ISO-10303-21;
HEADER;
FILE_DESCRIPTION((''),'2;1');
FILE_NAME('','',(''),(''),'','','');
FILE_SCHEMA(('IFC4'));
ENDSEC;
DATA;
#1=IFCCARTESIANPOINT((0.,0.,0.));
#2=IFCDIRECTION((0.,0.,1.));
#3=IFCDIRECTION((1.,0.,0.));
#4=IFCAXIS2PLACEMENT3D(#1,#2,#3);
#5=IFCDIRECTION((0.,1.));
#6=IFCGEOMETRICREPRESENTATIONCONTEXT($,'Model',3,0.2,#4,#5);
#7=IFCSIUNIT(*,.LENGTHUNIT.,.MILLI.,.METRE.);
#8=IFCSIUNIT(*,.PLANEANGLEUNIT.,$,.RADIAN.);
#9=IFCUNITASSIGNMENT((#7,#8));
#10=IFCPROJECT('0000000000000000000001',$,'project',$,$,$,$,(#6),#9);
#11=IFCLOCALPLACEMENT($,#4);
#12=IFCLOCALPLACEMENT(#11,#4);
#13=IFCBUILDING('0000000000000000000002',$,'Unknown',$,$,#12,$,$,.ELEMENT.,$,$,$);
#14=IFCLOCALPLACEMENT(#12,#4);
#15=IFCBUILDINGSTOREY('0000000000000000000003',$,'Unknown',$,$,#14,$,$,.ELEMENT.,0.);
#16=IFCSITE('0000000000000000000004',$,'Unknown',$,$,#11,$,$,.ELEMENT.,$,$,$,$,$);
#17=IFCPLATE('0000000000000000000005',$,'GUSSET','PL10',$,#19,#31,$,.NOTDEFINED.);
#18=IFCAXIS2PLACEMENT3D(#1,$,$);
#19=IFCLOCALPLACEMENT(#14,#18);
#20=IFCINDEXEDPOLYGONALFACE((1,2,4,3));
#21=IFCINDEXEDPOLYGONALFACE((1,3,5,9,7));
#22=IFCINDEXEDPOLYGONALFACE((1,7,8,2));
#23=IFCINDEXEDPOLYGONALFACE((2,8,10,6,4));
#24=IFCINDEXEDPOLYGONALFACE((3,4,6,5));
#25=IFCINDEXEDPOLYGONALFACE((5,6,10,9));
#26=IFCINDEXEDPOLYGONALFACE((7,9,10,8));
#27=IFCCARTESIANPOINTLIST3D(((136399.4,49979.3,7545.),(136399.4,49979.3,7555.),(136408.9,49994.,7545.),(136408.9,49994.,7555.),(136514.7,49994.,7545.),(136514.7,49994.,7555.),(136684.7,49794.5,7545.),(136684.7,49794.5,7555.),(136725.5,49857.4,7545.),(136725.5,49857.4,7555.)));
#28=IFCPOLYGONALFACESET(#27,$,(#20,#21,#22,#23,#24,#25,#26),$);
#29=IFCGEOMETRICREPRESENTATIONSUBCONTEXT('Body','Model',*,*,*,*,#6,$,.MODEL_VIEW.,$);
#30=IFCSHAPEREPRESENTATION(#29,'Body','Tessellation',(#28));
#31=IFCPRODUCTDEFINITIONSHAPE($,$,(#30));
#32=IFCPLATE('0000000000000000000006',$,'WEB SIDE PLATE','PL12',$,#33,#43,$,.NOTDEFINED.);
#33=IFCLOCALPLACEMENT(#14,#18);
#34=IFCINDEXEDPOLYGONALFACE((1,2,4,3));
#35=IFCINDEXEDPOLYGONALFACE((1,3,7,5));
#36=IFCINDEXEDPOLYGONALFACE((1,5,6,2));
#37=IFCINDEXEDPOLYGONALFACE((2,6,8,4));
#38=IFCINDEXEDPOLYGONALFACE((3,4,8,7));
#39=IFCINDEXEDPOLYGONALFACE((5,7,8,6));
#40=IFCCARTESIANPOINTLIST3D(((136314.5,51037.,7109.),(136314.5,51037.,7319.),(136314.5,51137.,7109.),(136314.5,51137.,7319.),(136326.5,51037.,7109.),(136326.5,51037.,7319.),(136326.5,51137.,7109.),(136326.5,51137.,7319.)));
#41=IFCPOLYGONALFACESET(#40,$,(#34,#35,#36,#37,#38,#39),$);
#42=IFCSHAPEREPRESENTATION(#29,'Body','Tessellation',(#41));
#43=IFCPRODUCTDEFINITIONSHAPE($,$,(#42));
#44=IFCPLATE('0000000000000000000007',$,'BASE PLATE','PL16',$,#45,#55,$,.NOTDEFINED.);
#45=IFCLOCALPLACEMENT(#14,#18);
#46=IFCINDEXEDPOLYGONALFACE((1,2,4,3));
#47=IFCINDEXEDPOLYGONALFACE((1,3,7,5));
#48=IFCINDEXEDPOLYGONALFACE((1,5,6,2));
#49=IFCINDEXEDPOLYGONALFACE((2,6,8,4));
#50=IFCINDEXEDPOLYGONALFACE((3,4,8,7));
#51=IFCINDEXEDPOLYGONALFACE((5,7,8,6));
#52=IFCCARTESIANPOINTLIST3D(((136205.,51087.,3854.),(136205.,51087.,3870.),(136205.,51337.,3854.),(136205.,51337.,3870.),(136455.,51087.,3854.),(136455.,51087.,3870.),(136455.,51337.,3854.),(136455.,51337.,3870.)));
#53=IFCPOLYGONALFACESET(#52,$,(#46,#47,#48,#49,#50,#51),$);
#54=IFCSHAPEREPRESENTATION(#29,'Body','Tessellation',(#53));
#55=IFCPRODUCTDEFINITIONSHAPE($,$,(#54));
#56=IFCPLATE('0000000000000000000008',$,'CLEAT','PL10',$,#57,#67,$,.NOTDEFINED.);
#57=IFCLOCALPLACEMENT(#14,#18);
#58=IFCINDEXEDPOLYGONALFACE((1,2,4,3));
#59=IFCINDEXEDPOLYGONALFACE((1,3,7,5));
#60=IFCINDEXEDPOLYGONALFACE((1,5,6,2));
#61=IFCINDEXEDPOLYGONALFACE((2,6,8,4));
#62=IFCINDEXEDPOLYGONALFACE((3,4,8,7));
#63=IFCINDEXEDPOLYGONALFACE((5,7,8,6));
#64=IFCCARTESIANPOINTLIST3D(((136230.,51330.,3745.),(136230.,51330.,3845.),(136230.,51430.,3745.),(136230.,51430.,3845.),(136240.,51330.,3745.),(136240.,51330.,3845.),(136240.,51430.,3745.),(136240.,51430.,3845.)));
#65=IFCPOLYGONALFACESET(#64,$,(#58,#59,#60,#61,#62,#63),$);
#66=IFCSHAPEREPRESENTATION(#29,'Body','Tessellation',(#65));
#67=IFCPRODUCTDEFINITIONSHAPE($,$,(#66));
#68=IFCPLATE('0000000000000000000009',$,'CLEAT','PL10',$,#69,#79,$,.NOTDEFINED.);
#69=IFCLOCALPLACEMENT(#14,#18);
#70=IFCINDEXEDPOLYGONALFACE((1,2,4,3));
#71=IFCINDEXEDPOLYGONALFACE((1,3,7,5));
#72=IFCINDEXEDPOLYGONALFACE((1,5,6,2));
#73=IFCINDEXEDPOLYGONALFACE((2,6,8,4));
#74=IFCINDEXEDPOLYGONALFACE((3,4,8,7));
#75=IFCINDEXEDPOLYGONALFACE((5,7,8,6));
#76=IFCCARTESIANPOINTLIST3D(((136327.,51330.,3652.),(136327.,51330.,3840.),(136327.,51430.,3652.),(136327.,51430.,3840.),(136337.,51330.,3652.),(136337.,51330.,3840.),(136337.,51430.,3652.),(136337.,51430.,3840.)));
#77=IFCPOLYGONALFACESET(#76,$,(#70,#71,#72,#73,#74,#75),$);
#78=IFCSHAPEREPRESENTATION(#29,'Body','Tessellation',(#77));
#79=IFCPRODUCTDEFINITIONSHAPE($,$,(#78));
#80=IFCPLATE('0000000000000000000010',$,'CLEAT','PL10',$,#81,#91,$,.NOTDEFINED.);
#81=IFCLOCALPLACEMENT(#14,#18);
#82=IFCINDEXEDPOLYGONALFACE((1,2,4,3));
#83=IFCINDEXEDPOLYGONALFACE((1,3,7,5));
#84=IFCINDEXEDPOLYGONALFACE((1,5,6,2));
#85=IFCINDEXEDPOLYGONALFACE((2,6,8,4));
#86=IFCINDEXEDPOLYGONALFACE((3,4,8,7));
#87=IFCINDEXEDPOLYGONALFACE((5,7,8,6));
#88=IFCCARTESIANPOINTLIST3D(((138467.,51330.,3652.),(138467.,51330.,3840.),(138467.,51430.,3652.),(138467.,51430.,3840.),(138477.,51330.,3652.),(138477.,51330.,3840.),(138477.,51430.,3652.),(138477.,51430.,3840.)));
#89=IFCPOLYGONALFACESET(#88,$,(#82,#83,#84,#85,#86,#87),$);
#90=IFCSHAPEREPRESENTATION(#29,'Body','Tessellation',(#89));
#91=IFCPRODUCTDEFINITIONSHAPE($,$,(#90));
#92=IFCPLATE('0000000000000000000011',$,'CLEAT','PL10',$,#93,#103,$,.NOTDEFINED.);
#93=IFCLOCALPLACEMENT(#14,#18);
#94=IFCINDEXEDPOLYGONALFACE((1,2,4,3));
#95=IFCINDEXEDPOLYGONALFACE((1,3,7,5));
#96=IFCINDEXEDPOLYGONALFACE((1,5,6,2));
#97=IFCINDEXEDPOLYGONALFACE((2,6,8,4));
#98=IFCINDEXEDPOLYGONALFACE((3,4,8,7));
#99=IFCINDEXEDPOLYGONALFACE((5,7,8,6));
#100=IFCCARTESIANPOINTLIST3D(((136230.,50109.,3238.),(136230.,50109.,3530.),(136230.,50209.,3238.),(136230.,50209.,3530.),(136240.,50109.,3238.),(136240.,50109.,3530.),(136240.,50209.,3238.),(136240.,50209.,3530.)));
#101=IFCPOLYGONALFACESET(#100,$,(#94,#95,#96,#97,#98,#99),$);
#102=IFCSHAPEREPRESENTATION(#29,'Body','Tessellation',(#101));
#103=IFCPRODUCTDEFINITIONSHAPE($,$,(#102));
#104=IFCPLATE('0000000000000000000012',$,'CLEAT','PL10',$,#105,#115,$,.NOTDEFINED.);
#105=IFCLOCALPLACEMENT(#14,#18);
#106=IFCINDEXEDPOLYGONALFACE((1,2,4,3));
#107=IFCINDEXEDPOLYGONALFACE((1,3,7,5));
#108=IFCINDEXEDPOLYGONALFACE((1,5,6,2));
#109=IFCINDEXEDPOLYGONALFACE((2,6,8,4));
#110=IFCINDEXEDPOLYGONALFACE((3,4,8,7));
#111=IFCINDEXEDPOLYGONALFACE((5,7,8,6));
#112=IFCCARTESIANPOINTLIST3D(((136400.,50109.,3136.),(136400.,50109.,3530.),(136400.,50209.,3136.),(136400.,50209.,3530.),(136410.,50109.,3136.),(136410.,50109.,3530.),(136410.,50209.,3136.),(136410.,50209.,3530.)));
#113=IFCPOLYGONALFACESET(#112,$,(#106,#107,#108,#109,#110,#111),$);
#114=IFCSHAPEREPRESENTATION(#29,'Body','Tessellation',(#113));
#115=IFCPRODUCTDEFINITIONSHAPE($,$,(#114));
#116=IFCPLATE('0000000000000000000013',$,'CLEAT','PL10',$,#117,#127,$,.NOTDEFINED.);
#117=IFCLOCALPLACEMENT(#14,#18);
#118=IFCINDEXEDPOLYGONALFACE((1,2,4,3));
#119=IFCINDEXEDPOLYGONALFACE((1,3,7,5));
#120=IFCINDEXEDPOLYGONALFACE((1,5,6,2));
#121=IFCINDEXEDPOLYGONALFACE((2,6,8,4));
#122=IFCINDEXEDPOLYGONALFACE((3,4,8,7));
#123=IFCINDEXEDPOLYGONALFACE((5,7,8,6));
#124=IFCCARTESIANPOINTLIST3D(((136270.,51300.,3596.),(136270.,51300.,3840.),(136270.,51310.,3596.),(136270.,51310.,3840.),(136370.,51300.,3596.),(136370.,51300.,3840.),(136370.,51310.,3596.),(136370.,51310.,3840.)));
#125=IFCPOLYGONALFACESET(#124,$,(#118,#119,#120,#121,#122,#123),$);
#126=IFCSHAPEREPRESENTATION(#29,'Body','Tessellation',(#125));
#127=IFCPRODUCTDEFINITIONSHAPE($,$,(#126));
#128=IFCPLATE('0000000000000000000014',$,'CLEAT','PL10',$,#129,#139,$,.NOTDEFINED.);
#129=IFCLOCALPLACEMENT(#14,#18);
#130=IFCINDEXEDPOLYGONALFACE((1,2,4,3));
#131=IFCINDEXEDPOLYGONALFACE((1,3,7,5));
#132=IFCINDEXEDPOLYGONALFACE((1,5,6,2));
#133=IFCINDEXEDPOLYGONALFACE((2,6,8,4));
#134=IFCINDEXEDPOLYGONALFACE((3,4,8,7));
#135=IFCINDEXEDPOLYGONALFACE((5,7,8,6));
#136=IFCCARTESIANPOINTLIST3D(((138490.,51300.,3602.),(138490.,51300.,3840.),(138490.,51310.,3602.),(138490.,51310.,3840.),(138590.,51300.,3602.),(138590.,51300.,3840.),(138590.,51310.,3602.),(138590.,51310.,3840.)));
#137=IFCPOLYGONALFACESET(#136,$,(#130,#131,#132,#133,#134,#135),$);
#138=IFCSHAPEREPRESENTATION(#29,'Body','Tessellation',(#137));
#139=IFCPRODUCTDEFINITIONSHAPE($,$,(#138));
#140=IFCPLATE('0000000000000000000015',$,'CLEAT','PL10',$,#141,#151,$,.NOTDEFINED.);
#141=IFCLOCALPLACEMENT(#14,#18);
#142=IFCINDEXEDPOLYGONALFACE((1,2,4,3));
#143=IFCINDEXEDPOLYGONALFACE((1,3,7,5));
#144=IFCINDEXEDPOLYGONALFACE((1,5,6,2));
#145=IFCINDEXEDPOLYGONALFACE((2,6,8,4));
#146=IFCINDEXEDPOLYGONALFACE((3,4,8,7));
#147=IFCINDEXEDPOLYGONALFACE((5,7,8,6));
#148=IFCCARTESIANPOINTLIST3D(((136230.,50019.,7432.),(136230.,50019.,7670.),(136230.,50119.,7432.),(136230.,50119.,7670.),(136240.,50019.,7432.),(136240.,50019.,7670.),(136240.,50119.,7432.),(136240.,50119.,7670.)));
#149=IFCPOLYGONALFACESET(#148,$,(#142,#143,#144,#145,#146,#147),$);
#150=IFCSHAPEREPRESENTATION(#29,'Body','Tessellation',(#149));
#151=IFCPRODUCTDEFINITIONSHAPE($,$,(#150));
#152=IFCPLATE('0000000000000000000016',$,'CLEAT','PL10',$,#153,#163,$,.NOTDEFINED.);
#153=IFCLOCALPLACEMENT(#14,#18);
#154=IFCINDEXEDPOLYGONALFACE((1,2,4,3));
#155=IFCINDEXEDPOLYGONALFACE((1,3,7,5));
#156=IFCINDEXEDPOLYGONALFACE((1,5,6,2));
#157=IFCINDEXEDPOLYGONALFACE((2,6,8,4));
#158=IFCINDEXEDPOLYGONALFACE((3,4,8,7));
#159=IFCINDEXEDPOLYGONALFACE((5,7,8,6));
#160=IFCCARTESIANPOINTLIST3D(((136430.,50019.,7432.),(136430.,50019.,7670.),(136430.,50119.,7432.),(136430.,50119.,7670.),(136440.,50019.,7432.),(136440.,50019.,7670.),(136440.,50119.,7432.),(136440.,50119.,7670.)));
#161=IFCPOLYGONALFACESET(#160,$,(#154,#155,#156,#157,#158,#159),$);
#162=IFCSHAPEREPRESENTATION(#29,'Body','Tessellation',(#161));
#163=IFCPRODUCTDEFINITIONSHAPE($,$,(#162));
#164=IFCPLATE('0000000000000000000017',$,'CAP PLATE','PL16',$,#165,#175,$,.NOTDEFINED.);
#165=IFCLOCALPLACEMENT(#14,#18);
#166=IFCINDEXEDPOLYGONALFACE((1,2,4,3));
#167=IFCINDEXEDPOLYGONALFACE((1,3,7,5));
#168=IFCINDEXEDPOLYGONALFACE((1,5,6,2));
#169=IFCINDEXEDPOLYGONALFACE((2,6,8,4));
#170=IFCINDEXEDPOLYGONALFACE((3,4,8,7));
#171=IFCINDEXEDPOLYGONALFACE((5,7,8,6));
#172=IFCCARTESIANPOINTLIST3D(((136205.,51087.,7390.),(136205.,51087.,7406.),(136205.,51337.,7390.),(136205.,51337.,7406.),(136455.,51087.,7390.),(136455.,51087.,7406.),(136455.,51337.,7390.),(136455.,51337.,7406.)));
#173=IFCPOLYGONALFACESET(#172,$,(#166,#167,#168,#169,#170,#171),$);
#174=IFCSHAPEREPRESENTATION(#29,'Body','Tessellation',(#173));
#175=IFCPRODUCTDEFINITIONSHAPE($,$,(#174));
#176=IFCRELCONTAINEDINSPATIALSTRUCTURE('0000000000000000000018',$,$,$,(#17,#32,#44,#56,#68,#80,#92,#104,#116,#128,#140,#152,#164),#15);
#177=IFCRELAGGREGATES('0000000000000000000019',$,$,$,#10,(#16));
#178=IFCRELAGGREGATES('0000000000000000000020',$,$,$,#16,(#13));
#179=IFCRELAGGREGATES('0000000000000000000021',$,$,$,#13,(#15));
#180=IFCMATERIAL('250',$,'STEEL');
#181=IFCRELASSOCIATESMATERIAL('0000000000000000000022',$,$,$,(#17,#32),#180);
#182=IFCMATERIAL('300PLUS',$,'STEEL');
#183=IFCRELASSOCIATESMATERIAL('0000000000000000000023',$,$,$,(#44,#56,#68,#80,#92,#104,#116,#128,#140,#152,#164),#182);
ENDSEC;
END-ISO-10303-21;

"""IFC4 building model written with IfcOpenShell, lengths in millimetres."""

from ifc_helpers import new_model, si_unit, direction, frame, origin_with_axes, place, context, subcontext, project, spatial, line, indexed_curve, outline, extrude, material, element, save


model = new_model("IFC4")

# Units and contexts
model_context = context("Model", 3, precision=0.2, world=origin_with_axes(), true_north=direction((0.0, 1.0)))
body_context = subcontext(model_context, "Body", "Model", "MODEL_VIEW")
ifc_project = project(units=[si_unit("LENGTHUNIT", "METRE", prefix="MILLI"), si_unit("PLANEANGLEUNIT", "RADIAN")], contexts=[model_context])

# Site, building, storey
site_placement = place(None, origin_with_axes())
site = spatial("IfcSite", under=ifc_project, at=site_placement, Name="Unknown", CompositionType="ELEMENT")
building_placement = place(site_placement, origin_with_axes())
building = spatial("IfcBuilding", under=site, at=building_placement, Name="Unknown", CompositionType="ELEMENT")
storey_placement = place(building_placement, origin_with_axes())
storey = spatial("IfcBuildingStorey", under=building, at=storey_placement, Name="Unknown", CompositionType="ELEMENT", Elevation=0.0)

# Shared definitions
ifc_material_1 = material(Name="300PLUS", Category="STEEL")

# Plates
ifc_material_2 = material(Name="250", Category="STEEL")
plate_1_placement = place(storey_placement, frame((136399.4, 49979.3, 7550.0), z_axis=(0.0, 0.0, 1.0), x_axis=(0.83931, -0.543654, 0.0)))
element("IfcPlate", 1, at=plate_1_placement, inside=storey, material=ifc_material_2, Name="GUSSET", Description="PL10", PredefinedType="NOTDEFINED", context=body_context, shape_type="SolidModel", body=[
    extrude(outline(indexed_curve([(0.0, 0.0), (339.9, 0.0), (340.0, 75.0), (88.8, 75.0), (0.0, 17.5)], segments=[line(1, 2, 3, 4, 5, 1)])), frame((0.0, 0.0, 5.0), z_axis=(0.0, 0.0, 1.0), x_axis=(1.0, 0.0, 0.0)), (0.0, 0.0, -1.0), 10.0),
])
plate_2_placement = place(storey_placement, frame((136320.5, 51137.0, 7109.0), z_axis=(-1.0, 0.0, 0.0), x_axis=(0.0, -1.0, 0.0)))
element("IfcPlate", 2, at=plate_2_placement, inside=storey, material=ifc_material_2, Name="WEB SIDE PLATE", Description="PL12", PredefinedType="NOTDEFINED", context=body_context, shape_type="SolidModel", body=[
    extrude(outline(indexed_curve([(0.0, 0.0), (100.0, 0.0), (100.0, 210.0), (0.0, 210.0)], segments=[line(1, 2, 3, 4, 1)])), frame((0.0, 0.0, 6.0), z_axis=(0.0, 0.0, 1.0), x_axis=(1.0, 0.0, 0.0)), (0.0, 0.0, -1.0), 12.0),
])
plate_3_placement = place(storey_placement, frame((136205.0, 51087.0, 3862.0), z_axis=(0.0, 0.0, 1.0), x_axis=(1.0, 0.0, 0.0)))
element("IfcPlate", 3, at=plate_3_placement, inside=storey, material=ifc_material_1, Name="BASE PLATE", Description="PL16", PredefinedType="NOTDEFINED", context=body_context, shape_type="SolidModel", body=[
    extrude(outline(indexed_curve([(0.0, 0.0), (250.0, 0.0), (250.0, 250.0), (0.0, 250.0)], segments=[line(1, 2, 3, 4, 1)])), frame((0.0, 0.0, 8.0), z_axis=(0.0, 0.0, 1.0), x_axis=(1.0, 0.0, 0.0)), (0.0, 0.0, -1.0), 16.0),
])
plate_4_placement = place(storey_placement, frame((136235.0, 51330.0, 3745.0), z_axis=(1.0, 0.0, 0.0), x_axis=(0.0, 1.0, 0.0)))
element("IfcPlate", 4, at=plate_4_placement, inside=storey, material=ifc_material_1, Name="CLEAT", Description="PL10", PredefinedType="NOTDEFINED", context=body_context, shape_type="SolidModel", body=[
    extrude(outline(indexed_curve([(0.0, 0.0), (100.0, 0.0), (100.0, 100.0), (0.0, 100.0)], segments=[line(1, 2, 3, 4, 1)])), frame((0.0, 0.0, 5.0), z_axis=(0.0, 0.0, 1.0), x_axis=(1.0, 0.0, 0.0)), (0.0, 0.0, -1.0), 10.0),
])
for number, where, z_axis, x_axis, name in (
    (5, (136332.0, 51330.0, 3652.0), (1.0, 0.0, 0.0), (0.0, 1.0, 0.0), "CLEAT"),
    (6, (138472.0, 51330.0, 3652.0), (1.0, 0.0, 0.0), (0.0, 1.0, 0.0), "CLEAT"),
):
    element("IfcPlate", number, at=place(storey_placement, frame(where, z_axis=z_axis, x_axis=x_axis)), inside=storey, material=ifc_material_1, Name=name, Description="PL10", PredefinedType="NOTDEFINED", context=body_context, shape_type="SolidModel", body=[
        extrude(outline(indexed_curve([(0.0, 0.0), (100.0, 0.0), (100.0, 188.0), (0.0, 188.0)], segments=[line(1, 2, 3, 4, 1)])), frame((0.0, 0.0, 5.0), z_axis=(0.0, 0.0, 1.0), x_axis=(1.0, 0.0, 0.0)), (0.0, 0.0, -1.0), 10.0),
    ])
plate_5_placement = place(storey_placement, frame((136235.0, 50109.0, 3238.0), z_axis=(1.0, 0.0, 0.0), x_axis=(0.0, 1.0, 0.0)))
element("IfcPlate", 7, at=plate_5_placement, inside=storey, material=ifc_material_1, Name="CLEAT", Description="PL10", PredefinedType="NOTDEFINED", context=body_context, shape_type="SolidModel", body=[
    extrude(outline(indexed_curve([(0.0, 0.0), (100.0, 0.0), (100.0, 292.0), (0.0, 292.0)], segments=[line(1, 2, 3, 4, 1)])), frame((0.0, 0.0, 5.0), z_axis=(0.0, 0.0, 1.0), x_axis=(1.0, 0.0, 0.0)), (0.0, 0.0, -1.0), 10.0),
])
plate_6_placement = place(storey_placement, frame((136405.0, 50109.0, 3136.0), z_axis=(1.0, 0.0, 0.0), x_axis=(0.0, 1.0, 0.0)))
element("IfcPlate", 8, at=plate_6_placement, inside=storey, material=ifc_material_1, Name="CLEAT", Description="PL10", PredefinedType="NOTDEFINED", context=body_context, shape_type="SolidModel", body=[
    extrude(outline(indexed_curve([(0.0, 0.0), (100.0, 0.0), (100.0, 394.0), (0.0, 394.0)], segments=[line(1, 2, 3, 4, 1)])), frame((0.0, 0.0, 5.0), z_axis=(0.0, 0.0, 1.0), x_axis=(1.0, 0.0, 0.0)), (0.0, 0.0, -1.0), 10.0),
])
plate_7_placement = place(storey_placement, frame((136270.0, 51305.0, 3596.0), z_axis=(0.0, -1.0, 0.0), x_axis=(1.0, 0.0, 0.0)))
element("IfcPlate", 9, at=plate_7_placement, inside=storey, material=ifc_material_1, Name="CLEAT", Description="PL10", PredefinedType="NOTDEFINED", context=body_context, shape_type="SolidModel", body=[
    extrude(outline(indexed_curve([(0.0, 0.0), (100.0, 0.0), (100.0, 244.0), (0.0, 244.0)], segments=[line(1, 2, 3, 4, 1)])), frame((0.0, 0.0, 5.0), z_axis=(0.0, 0.0, 1.0), x_axis=(1.0, 0.0, 0.0)), (0.0, 0.0, -1.0), 10.0),
])
for number, where, z_axis, x_axis, name in (
    (10, (138490.0, 51305.0, 3602.0), (0.0, -1.0, 0.0), (1.0, 0.0, 0.0), "CLEAT"),
    (11, (136235.0, 50019.0, 7432.0), (1.0, 0.0, 0.0), (0.0, 1.0, 0.0), "CLEAT"),
    (12, (136435.0, 50019.0, 7432.0), (1.0, 0.0, 0.0), (0.0, 1.0, 0.0), "CLEAT"),
):
    element("IfcPlate", number, at=place(storey_placement, frame(where, z_axis=z_axis, x_axis=x_axis)), inside=storey, material=ifc_material_1, Name=name, Description="PL10", PredefinedType="NOTDEFINED", context=body_context, shape_type="SolidModel", body=[
        extrude(outline(indexed_curve([(0.0, 0.0), (100.0, 0.0), (100.0, 238.0), (0.0, 238.0)], segments=[line(1, 2, 3, 4, 1)])), frame((0.0, 0.0, 5.0), z_axis=(0.0, 0.0, 1.0), x_axis=(1.0, 0.0, 0.0)), (0.0, 0.0, -1.0), 10.0),
    ])
plate_8_placement = place(storey_placement, frame((136205.0, 51087.0, 7398.0), z_axis=(0.0, 0.0, 1.0), x_axis=(1.0, 0.0, 0.0)))
element("IfcPlate", 13, at=plate_8_placement, inside=storey, material=ifc_material_1, Name="CAP PLATE", Description="PL16", PredefinedType="NOTDEFINED", context=body_context, shape_type="SolidModel", body=[
    extrude(outline(indexed_curve([(0.0, 0.0), (250.0, 0.0), (250.0, 250.0), (0.0, 250.0)], segments=[line(1, 2, 3, 4, 1)])), frame((0.0, 0.0, 8.0), z_axis=(0.0, 0.0, 1.0), x_axis=(1.0, 0.0, 0.0)), (0.0, 0.0, -1.0), 16.0),
])

save(model, "model.ifc")
